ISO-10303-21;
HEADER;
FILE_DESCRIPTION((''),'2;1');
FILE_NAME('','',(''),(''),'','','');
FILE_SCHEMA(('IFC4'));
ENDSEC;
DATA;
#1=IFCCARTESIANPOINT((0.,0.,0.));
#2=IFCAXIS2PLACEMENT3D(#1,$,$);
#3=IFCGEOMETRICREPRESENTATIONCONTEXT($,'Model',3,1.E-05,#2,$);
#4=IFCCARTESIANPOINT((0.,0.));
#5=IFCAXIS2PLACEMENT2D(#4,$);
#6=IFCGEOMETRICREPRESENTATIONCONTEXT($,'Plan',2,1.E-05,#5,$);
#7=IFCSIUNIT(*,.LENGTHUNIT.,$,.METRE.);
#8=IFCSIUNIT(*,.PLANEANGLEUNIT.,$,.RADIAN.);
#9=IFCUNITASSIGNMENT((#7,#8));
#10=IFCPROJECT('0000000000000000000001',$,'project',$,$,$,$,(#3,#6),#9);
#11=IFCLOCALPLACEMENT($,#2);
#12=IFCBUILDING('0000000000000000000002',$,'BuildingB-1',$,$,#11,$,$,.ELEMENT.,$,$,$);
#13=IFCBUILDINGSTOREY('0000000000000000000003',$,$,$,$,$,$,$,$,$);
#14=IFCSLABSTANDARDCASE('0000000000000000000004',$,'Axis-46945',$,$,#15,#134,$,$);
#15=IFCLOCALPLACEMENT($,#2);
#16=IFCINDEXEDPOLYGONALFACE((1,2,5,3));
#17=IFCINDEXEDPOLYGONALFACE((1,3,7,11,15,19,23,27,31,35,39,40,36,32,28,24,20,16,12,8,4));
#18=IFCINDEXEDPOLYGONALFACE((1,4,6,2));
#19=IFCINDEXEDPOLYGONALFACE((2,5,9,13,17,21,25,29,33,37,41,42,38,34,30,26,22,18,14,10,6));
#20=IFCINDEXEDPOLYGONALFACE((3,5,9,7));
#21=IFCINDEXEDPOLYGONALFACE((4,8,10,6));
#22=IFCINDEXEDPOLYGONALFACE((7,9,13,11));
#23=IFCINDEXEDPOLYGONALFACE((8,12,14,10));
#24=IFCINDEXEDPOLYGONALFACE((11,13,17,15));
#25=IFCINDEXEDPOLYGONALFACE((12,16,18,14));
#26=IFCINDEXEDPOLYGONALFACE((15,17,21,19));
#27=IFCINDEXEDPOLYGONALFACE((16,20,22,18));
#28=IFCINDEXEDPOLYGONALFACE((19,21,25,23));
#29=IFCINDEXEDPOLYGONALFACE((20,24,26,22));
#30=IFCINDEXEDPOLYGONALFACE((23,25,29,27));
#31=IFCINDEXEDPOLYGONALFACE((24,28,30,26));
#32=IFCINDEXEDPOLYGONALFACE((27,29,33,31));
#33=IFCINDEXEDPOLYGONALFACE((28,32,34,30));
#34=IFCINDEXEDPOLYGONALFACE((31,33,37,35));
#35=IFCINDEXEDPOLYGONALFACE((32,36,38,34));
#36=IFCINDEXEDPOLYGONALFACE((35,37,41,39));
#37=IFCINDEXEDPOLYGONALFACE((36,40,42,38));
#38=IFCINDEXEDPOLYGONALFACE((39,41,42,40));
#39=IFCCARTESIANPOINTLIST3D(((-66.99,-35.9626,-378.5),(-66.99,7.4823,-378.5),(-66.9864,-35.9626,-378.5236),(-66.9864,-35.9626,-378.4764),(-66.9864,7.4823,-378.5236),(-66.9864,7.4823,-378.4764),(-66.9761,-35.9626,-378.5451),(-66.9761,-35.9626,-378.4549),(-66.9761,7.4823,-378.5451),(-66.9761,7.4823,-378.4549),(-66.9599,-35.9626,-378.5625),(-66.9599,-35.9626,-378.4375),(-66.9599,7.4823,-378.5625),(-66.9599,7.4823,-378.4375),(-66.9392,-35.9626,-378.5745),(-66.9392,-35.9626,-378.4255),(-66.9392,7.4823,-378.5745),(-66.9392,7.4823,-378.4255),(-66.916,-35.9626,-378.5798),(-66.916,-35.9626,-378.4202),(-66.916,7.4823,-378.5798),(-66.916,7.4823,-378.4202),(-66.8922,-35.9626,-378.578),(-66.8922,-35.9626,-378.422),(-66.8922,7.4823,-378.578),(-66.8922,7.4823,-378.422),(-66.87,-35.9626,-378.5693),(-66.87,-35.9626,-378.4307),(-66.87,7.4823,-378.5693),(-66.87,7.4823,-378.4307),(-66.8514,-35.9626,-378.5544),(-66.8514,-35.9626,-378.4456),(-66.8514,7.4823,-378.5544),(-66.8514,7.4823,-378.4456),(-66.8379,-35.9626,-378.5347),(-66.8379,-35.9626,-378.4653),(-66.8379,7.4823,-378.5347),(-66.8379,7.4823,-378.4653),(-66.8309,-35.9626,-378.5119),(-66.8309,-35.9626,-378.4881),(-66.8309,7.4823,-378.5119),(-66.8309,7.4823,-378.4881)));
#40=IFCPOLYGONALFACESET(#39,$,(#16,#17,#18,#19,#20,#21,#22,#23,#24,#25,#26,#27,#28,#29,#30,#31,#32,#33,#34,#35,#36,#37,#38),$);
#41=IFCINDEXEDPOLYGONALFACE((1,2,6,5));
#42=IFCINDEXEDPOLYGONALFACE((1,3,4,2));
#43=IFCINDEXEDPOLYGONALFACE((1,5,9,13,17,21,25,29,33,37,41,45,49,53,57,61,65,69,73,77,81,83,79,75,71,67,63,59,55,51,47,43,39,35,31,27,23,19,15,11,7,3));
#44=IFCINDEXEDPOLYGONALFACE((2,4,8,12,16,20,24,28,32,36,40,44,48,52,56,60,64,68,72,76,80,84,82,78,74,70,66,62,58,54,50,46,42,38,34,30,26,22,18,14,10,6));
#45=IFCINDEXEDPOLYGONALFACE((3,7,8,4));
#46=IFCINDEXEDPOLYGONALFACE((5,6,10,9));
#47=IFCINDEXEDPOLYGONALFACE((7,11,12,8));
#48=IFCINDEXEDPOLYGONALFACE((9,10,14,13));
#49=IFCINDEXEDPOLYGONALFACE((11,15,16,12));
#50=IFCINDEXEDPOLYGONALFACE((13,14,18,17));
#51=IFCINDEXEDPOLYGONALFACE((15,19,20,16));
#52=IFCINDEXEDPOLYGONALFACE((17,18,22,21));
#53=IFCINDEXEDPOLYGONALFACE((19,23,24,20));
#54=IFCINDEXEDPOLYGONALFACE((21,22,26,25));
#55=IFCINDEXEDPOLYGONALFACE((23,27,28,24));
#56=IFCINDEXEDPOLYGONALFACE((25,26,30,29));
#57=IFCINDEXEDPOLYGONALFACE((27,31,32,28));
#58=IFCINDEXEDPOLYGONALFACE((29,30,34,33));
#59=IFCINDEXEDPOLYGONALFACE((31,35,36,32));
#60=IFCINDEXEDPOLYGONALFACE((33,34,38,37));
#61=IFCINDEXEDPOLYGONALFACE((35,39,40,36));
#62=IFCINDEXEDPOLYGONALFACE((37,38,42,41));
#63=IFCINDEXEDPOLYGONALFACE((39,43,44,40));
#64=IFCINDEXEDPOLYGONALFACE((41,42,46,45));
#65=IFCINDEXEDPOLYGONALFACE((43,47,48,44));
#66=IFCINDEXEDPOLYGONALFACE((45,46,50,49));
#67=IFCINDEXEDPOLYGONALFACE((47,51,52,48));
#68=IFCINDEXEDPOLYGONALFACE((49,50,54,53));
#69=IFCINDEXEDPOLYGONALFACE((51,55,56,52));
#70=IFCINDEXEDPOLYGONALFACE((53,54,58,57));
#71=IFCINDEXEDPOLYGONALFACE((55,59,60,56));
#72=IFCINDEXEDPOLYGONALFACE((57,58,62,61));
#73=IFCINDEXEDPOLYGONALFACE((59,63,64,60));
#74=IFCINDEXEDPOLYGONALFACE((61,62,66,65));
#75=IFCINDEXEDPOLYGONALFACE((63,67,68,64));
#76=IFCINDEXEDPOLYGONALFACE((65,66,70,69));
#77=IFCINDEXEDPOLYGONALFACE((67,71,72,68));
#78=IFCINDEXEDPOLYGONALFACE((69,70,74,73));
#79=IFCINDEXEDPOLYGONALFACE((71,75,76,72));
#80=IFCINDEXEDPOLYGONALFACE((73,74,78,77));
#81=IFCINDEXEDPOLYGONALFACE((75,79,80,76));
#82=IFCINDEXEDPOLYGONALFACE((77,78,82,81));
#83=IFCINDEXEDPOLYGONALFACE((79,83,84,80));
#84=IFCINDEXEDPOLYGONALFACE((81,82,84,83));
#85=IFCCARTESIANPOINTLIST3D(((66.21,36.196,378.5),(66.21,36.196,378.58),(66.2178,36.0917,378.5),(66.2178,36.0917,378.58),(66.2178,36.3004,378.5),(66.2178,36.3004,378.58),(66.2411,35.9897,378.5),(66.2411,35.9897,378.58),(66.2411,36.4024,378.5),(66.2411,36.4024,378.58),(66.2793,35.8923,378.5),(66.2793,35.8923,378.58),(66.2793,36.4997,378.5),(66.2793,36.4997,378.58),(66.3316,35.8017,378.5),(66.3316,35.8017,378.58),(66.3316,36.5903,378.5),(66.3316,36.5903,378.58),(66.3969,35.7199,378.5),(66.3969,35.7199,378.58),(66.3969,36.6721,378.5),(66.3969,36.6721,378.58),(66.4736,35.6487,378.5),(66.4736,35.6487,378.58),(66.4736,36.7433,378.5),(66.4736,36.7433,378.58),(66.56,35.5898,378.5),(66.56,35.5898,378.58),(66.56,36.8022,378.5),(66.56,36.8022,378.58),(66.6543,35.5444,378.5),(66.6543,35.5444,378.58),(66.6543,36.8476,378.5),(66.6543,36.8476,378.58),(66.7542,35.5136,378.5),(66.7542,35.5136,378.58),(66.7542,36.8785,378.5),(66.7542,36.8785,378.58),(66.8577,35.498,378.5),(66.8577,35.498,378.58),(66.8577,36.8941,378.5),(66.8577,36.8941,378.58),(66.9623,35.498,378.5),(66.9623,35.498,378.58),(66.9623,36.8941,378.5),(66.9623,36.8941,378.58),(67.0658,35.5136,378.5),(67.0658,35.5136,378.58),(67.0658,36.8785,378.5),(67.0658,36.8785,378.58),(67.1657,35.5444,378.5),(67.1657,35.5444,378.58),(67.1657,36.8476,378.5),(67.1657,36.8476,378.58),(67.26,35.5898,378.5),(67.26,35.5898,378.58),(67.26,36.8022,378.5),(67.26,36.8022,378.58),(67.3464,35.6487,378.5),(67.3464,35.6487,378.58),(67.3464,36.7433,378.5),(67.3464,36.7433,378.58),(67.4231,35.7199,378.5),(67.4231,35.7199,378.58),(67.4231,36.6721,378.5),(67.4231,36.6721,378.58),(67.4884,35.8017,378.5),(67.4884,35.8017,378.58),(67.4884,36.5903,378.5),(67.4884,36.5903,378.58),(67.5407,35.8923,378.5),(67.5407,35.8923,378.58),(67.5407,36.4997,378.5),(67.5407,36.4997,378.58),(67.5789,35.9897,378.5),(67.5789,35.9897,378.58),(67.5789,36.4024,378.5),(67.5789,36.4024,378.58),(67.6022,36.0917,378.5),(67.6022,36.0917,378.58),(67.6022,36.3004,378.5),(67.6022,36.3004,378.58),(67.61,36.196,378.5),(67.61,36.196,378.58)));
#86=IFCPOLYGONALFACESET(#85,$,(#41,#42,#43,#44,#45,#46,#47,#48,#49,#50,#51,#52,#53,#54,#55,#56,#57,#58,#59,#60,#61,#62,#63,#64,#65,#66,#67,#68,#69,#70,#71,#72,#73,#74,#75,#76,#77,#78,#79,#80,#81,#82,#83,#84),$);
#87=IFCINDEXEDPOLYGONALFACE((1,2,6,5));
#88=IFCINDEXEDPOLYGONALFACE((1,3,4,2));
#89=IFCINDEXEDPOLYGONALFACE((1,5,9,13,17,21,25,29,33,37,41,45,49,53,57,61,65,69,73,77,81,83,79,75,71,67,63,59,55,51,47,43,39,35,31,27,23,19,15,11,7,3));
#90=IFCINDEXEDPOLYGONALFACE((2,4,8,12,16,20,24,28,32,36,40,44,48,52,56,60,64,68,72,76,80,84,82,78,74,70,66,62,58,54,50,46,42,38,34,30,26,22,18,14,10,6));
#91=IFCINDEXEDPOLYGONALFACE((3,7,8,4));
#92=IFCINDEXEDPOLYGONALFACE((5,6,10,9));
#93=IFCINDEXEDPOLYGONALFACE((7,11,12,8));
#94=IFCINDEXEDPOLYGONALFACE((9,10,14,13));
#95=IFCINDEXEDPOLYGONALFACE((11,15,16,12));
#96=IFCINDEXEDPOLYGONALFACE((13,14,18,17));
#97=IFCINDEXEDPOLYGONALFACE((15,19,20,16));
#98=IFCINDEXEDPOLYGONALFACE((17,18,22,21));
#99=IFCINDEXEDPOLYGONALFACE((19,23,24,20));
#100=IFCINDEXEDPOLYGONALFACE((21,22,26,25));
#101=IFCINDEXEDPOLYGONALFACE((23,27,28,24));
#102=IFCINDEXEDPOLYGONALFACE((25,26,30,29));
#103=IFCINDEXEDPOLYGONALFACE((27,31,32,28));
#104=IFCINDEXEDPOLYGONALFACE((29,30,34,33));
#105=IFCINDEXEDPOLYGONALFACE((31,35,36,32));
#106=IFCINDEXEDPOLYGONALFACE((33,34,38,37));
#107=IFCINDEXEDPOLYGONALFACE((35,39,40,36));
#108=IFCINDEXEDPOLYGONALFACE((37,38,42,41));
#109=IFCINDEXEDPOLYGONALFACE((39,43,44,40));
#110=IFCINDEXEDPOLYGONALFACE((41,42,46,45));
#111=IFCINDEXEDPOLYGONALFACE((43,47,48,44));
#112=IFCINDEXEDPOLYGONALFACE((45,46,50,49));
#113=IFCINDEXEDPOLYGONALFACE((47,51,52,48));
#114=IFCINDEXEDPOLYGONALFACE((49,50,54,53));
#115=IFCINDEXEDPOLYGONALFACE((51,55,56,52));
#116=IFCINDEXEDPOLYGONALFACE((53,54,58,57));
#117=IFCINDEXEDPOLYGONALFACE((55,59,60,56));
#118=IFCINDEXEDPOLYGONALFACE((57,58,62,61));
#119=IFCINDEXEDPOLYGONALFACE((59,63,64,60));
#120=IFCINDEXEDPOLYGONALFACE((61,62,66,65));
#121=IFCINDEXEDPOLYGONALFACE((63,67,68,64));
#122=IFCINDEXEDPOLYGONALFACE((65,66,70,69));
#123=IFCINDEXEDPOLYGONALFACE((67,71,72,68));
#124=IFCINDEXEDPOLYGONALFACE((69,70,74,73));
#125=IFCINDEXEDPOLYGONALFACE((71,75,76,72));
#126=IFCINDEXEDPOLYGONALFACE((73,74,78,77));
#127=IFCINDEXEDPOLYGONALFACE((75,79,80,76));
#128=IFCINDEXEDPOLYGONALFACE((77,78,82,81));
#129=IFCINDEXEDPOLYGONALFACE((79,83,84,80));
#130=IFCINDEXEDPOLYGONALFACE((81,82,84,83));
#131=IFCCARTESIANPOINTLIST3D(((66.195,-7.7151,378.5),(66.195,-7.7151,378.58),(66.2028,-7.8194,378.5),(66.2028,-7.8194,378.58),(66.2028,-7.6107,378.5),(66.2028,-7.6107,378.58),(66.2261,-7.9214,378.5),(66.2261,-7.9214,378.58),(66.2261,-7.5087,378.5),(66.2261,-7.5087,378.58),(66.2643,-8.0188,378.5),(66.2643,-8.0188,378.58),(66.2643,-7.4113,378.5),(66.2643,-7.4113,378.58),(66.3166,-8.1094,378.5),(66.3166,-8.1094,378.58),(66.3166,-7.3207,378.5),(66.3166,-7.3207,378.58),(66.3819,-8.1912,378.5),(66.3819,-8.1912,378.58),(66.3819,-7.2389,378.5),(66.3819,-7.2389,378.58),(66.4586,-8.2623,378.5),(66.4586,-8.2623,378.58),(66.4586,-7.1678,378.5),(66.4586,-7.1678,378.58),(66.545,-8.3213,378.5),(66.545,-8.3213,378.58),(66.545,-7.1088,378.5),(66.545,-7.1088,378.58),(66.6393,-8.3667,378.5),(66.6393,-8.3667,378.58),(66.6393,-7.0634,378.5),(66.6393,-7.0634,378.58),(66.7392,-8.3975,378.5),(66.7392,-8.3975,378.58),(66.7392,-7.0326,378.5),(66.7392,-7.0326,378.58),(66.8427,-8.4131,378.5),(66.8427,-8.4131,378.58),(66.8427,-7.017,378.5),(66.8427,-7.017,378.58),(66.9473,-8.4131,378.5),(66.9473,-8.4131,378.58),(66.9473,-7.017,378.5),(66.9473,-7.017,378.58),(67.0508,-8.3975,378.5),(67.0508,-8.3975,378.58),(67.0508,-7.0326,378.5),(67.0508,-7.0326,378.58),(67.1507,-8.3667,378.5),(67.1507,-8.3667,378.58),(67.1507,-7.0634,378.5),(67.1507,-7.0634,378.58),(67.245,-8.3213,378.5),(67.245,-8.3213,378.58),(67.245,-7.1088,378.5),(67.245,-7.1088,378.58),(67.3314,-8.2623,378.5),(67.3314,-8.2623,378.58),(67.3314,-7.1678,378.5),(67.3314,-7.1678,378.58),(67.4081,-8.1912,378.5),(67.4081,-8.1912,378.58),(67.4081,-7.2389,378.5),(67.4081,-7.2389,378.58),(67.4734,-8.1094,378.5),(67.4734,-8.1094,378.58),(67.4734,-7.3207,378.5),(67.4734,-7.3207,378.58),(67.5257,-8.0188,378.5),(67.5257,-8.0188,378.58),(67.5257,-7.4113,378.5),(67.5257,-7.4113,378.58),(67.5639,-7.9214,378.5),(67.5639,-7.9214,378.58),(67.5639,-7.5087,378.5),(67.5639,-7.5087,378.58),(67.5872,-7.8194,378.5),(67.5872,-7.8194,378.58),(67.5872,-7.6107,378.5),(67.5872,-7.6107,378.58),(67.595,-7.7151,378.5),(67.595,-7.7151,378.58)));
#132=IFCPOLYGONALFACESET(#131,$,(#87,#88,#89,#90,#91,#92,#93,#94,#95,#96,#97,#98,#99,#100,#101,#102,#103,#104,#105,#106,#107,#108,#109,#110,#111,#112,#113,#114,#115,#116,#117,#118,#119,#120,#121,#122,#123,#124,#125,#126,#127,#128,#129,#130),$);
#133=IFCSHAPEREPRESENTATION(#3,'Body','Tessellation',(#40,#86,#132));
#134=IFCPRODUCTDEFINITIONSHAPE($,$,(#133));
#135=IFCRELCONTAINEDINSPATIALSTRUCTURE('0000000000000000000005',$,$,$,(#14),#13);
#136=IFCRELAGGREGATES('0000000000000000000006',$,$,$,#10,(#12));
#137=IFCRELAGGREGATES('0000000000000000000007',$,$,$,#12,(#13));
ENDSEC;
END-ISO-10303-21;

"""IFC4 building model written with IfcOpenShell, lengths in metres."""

from ifc_helpers import new_model, entity, si_unit, frame, origin, origin_2d, place, context, project, spatial, circle, extrude, element, save


model = new_model("IFC4")

# Units and contexts
model_context = context("Model", 3, precision=1e-05, world=origin())
plan_context = context("Plan", 2, precision=1e-05, world=origin_2d())
ifc_project = project(units=[si_unit("LENGTHUNIT", "METRE"), si_unit("PLANEANGLEUNIT", "RADIAN")], contexts=[model_context, plan_context])

# Building, storey
building_placement = place(None, origin())
building = spatial("IfcBuilding", under=ifc_project, at=building_placement, Name="BuildingB-1", CompositionType="ELEMENT")
storey = spatial("IfcBuildingStorey", under=building)

# Slab
element("IfcSlabStandardCase", 1, inside=storey, Name="Axis-46945", context=model_context, shape_type="AdvancedSweptSolid", body=[
    entity("IfcSurfaceCurveSweptAreaSolid", entity("IfcCircleProfileDef", "AREA", None, None, 0.08), None, entity("IfcPolyline", [entity("IfcCartesianPoint", [66.91, 35.9626, 378.5]), entity("IfcCartesianPoint", [66.91, -7.4823, 378.5])]), None, None, entity("IfcPlane", entity("IfcAxis2Placement3D", entity("IfcCartesianPoint", [66.91, 35.9626, 378.5]), entity("IfcDirection", [0.0, 0.0, 1.0]), entity("IfcDirection", [1.0, 0.0, 0.0])))),
    extrude(circle(Radius=0.7), frame((66.91, 36.196, 378.5)), (0.0, 0.0, 1.0), 0.08),
    extrude(circle(Radius=0.7), frame((66.895, -7.7151, 378.5)), (0.0, 0.0, 1.0), 0.08),
])

save(model, "model.ifc")
